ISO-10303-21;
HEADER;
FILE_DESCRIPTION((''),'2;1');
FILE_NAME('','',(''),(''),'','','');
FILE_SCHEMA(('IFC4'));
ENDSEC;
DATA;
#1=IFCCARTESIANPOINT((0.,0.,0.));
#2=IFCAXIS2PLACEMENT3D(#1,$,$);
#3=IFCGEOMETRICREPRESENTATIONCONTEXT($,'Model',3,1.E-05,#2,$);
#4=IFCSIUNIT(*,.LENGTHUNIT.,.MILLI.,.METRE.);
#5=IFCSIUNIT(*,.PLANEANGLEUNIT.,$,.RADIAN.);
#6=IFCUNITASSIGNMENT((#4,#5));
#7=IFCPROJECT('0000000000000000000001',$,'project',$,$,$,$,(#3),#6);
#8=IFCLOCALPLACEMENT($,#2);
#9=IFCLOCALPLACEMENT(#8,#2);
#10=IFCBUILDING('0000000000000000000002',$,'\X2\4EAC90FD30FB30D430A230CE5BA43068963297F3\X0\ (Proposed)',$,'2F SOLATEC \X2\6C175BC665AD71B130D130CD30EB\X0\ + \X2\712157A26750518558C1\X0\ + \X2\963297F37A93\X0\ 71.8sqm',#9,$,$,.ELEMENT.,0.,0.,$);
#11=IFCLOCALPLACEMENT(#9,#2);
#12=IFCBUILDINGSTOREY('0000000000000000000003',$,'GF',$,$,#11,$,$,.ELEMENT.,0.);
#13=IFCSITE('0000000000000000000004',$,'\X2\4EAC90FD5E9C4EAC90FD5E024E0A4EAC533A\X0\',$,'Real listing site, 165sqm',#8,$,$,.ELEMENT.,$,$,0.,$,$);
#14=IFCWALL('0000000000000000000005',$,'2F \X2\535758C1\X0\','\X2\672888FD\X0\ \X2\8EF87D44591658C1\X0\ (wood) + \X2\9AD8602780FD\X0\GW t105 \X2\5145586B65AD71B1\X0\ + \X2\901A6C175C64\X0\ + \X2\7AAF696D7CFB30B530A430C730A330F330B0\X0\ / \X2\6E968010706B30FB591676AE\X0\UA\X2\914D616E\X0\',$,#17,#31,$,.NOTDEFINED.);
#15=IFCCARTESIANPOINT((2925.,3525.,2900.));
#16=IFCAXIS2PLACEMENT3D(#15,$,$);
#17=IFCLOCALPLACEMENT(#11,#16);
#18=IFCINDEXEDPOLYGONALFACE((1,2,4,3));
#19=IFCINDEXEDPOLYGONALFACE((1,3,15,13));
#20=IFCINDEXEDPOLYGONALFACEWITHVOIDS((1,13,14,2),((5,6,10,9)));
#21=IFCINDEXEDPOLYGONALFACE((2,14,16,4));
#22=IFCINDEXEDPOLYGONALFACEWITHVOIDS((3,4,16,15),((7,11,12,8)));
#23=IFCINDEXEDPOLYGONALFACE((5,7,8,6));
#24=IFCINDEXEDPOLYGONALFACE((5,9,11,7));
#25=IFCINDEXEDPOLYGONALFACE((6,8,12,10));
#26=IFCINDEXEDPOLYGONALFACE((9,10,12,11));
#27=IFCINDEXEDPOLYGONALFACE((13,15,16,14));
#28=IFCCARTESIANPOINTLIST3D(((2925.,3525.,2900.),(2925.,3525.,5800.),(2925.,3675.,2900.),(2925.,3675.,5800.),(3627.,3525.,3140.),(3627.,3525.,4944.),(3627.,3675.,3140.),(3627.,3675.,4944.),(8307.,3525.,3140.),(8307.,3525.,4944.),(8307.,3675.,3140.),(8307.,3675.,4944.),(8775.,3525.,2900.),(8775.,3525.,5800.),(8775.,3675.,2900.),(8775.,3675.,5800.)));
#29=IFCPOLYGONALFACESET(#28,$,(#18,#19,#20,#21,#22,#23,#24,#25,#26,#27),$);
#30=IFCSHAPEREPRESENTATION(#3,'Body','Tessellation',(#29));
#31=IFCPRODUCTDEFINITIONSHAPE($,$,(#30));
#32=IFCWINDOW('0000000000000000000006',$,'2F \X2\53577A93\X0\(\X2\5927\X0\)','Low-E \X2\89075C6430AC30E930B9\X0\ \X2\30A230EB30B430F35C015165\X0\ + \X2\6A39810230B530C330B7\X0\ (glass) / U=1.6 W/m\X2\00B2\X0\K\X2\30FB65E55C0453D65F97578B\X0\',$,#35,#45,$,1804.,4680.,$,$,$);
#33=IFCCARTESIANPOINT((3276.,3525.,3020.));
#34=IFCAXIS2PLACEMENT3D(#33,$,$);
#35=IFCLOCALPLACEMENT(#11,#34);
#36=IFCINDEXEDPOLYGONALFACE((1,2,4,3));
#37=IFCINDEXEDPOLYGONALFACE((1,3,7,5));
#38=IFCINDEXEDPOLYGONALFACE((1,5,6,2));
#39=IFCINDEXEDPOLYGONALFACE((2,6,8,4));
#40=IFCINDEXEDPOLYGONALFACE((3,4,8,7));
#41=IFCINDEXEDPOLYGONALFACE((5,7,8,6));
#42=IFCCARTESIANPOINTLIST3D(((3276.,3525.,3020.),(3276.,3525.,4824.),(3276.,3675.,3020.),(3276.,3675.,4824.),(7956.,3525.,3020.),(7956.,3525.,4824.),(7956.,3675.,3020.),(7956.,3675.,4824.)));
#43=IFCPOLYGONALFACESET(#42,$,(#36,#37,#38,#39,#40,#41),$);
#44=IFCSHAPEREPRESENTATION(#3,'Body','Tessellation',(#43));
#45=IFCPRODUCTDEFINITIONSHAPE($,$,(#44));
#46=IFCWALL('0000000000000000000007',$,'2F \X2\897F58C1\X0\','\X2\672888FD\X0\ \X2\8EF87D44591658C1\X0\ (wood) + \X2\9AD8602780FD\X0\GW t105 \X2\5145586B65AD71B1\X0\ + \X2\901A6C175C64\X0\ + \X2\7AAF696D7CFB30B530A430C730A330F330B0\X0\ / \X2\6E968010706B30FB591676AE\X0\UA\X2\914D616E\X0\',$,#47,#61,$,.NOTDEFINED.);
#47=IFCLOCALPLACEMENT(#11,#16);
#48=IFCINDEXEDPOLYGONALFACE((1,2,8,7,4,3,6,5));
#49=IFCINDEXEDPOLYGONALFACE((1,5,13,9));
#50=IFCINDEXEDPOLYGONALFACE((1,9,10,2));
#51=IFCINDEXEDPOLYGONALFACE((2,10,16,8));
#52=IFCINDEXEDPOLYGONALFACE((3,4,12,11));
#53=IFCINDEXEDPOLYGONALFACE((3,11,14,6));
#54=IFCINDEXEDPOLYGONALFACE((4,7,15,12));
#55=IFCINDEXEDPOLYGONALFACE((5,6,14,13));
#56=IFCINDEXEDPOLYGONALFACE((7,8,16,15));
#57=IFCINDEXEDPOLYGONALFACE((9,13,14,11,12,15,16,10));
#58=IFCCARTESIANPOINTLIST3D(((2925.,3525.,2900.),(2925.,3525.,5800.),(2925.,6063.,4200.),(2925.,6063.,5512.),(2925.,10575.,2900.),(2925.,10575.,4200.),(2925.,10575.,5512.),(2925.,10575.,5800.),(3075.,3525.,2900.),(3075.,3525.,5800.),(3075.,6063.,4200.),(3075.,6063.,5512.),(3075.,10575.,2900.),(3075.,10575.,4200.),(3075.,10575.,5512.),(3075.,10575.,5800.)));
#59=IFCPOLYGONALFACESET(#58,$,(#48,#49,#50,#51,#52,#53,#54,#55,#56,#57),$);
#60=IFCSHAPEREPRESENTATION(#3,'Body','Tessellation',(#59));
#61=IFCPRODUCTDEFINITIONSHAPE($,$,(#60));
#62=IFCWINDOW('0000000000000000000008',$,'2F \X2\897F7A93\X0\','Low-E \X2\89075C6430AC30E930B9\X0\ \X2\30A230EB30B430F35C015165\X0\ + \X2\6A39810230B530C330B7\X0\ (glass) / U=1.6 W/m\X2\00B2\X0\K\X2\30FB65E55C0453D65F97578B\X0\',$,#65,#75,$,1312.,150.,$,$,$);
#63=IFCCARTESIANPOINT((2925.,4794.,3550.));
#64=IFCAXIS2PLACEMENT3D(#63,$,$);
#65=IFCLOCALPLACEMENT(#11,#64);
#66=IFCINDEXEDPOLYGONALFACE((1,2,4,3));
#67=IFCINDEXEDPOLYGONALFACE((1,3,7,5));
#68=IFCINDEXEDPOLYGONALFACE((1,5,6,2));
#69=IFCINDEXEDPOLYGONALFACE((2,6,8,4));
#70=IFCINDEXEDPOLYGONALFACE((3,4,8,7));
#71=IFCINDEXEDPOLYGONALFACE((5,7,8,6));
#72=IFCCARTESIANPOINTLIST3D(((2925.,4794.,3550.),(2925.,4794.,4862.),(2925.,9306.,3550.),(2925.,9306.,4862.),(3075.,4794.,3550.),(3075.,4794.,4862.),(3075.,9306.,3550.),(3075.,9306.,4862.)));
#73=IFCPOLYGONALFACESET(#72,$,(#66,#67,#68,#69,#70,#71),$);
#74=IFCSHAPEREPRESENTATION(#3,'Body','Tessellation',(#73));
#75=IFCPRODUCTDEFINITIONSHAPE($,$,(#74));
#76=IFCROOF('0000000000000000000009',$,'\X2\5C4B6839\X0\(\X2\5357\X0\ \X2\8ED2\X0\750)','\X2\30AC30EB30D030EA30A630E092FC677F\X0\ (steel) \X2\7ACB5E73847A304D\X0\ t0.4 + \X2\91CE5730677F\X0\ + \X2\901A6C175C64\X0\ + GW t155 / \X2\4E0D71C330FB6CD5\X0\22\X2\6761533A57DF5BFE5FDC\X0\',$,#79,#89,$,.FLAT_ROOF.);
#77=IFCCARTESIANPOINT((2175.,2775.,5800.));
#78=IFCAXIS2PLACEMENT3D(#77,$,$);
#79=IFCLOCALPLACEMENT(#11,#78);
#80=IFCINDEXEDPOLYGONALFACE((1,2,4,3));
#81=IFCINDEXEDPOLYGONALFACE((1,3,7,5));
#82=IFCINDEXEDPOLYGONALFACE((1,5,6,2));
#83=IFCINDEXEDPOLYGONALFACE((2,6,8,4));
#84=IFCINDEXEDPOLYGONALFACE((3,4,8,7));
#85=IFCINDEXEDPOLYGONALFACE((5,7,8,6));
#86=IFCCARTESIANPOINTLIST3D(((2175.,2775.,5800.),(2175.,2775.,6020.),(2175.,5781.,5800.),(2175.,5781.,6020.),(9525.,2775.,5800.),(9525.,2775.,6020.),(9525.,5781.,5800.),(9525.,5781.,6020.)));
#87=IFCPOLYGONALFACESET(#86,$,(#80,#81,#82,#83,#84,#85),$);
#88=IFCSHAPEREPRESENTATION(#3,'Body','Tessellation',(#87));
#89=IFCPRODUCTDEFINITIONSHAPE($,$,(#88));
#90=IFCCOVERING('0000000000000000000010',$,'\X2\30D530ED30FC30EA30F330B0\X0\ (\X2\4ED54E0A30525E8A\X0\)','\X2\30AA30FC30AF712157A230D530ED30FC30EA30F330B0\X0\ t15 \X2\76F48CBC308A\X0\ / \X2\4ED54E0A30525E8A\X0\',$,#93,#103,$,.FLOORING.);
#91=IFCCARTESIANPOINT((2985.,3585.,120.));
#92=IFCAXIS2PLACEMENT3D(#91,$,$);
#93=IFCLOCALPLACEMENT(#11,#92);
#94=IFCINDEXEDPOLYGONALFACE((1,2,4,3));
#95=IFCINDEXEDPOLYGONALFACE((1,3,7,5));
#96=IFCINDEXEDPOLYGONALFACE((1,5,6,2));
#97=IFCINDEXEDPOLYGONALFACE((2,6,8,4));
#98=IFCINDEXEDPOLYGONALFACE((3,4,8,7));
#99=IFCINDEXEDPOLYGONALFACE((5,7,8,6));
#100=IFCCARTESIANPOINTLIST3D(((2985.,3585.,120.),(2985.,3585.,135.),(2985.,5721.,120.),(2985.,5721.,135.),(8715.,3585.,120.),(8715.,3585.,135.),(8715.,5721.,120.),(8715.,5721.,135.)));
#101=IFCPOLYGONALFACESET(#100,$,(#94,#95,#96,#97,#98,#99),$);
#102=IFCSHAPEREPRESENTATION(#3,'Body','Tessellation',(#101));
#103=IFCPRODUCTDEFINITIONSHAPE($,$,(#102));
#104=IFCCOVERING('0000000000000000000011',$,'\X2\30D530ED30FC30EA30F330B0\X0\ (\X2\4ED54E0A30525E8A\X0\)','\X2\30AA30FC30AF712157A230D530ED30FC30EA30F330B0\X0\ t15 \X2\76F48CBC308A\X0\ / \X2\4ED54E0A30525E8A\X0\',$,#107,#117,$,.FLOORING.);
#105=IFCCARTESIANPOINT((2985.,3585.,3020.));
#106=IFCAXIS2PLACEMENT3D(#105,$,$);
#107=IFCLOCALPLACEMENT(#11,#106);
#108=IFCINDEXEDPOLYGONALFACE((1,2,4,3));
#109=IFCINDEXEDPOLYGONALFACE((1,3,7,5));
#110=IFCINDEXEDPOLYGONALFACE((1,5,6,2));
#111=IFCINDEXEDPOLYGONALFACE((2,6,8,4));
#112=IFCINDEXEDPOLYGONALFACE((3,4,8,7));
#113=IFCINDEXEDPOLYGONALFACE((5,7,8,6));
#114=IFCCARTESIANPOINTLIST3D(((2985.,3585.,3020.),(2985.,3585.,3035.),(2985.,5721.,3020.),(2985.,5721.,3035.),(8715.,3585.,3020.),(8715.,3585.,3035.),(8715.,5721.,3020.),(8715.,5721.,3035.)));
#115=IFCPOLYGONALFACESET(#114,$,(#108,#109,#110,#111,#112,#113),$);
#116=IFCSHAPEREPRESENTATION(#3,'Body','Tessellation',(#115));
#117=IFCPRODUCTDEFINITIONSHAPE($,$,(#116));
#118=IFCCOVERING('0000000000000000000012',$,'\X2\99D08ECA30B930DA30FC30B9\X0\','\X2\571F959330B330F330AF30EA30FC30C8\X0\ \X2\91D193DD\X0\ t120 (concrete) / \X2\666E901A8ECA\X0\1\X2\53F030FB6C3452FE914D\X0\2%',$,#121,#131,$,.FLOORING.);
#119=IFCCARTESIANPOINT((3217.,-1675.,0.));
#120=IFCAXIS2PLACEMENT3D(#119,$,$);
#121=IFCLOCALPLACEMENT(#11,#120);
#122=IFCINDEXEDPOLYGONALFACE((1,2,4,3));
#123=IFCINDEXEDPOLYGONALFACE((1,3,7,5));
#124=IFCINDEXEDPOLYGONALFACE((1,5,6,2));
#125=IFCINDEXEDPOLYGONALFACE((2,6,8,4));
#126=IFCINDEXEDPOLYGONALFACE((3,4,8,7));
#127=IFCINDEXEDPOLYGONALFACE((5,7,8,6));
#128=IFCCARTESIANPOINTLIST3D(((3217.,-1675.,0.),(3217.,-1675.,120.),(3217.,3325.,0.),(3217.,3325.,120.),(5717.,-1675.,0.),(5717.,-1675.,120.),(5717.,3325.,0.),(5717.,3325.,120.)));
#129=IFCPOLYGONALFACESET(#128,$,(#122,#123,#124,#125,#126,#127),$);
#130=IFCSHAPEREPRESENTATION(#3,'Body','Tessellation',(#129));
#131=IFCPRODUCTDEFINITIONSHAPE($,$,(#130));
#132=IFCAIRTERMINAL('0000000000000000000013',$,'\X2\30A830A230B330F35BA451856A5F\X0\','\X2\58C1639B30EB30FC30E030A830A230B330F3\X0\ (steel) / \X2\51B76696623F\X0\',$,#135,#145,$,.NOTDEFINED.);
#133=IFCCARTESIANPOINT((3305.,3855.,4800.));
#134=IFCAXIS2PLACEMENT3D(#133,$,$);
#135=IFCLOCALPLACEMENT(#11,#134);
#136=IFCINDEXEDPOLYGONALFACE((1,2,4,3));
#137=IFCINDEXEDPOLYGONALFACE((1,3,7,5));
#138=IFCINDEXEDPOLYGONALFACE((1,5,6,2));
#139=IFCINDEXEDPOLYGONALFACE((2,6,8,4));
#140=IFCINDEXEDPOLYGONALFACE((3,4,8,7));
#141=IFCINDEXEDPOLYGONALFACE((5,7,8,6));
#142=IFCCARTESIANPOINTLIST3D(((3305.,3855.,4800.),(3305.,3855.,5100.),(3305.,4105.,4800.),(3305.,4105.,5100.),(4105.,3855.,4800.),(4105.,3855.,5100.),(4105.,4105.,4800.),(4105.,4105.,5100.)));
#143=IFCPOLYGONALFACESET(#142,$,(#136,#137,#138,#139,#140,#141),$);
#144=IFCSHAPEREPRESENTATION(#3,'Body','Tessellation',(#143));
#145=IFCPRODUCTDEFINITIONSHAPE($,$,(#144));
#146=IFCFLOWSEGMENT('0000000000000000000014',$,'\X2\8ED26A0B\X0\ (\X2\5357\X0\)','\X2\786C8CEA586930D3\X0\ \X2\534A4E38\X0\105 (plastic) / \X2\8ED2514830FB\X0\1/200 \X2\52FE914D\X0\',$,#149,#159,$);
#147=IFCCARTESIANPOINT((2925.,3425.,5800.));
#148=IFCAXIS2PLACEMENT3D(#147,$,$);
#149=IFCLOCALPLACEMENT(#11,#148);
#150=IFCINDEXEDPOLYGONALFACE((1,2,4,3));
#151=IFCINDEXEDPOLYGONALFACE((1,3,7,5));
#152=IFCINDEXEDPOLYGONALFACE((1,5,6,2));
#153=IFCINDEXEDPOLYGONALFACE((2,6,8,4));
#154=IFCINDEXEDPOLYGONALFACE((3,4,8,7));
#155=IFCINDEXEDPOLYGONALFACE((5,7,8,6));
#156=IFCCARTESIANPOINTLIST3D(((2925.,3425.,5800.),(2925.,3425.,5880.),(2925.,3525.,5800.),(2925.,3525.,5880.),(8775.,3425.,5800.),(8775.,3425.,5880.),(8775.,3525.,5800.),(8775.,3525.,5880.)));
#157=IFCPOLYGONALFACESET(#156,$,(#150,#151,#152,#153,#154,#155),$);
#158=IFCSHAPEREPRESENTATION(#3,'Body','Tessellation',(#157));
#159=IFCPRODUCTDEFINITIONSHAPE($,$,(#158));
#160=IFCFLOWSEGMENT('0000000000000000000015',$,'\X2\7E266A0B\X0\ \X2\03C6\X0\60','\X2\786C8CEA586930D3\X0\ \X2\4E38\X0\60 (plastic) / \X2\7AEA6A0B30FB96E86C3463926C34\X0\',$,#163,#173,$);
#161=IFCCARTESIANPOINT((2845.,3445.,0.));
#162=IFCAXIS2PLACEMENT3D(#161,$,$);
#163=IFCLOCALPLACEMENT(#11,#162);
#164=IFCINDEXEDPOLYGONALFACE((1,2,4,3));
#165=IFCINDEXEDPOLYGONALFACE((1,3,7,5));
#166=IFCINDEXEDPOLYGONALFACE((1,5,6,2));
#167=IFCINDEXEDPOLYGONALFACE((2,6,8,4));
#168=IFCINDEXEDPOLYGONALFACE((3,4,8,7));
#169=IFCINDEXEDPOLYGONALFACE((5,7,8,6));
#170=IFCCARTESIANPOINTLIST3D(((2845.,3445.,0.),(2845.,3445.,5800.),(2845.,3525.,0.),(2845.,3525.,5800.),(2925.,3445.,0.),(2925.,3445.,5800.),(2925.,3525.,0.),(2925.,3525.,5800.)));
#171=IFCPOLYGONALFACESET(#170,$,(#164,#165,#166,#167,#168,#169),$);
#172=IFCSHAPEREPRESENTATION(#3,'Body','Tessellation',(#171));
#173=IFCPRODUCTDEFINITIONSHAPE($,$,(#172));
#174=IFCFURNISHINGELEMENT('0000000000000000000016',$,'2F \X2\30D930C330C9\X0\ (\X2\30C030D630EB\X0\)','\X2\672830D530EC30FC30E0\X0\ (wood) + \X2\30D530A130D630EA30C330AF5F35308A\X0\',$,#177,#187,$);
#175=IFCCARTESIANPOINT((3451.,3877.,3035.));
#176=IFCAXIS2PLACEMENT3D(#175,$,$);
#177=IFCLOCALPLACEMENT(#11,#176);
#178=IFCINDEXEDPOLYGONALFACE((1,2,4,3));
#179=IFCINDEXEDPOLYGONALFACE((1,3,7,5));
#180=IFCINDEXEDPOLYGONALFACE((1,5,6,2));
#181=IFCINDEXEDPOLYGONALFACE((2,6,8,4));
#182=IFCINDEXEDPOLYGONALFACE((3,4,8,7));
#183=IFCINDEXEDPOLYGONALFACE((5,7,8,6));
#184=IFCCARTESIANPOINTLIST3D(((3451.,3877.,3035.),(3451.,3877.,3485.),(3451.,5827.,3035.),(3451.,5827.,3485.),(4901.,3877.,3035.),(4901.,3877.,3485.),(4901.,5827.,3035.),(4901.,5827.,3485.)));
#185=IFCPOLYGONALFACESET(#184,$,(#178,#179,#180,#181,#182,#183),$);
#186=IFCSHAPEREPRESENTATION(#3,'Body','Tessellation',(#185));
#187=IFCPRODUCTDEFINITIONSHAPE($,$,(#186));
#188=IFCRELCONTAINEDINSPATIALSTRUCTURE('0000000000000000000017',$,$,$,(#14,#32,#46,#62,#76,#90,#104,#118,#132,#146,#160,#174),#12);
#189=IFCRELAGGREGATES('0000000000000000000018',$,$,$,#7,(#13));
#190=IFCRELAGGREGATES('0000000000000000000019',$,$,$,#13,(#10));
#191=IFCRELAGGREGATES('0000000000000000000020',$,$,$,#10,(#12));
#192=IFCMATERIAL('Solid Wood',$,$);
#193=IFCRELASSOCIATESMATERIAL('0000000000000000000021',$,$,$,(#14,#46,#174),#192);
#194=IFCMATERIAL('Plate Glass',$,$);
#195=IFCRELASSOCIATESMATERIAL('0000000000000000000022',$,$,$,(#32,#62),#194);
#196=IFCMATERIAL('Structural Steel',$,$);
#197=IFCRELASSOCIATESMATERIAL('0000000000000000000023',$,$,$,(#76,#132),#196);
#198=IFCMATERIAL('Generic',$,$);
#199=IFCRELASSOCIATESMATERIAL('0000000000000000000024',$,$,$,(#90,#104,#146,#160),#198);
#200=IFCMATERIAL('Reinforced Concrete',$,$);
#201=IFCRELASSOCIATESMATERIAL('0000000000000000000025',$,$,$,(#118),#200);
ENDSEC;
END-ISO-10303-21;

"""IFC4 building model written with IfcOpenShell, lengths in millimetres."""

from ifc_helpers import new_model, si_unit, frame, frame_2d, origin, place, context, project, spatial, rectangle, extrude, material, element, fill, save


model = new_model("IFC4")

# Units and contexts
model_context = context("Model", 3, precision=1e-05, world=origin())
ifc_project = project(units=[si_unit("LENGTHUNIT", "METRE", prefix="MILLI"), si_unit("PLANEANGLEUNIT", "RADIAN")], contexts=[model_context])

# Site, building, storey
site_placement = place(None, origin())
site = spatial("IfcSite", under=ifc_project, at=site_placement, Name="京都府京都市上京区", ObjectType="Real listing site, 165sqm", CompositionType="ELEMENT", RefElevation=0.0)
building_placement = place(site_placement, origin())
building = spatial("IfcBuilding", under=site, at=building_placement, Name="京都・ピアノ室と防音 (Proposed)", ObjectType="2F SOLATEC 気密断熱パネル + 無垢材内壁 + 防音窓 71.8sqm", CompositionType="ELEMENT", ElevationOfRefHeight=0.0, ElevationOfTerrain=0.0)
storey_placement = place(building_placement, origin())
storey = spatial("IfcBuildingStorey", under=building, at=storey_placement, Name="GF", CompositionType="ELEMENT", Elevation=0.0)

# Shared definitions
ifc_material_1 = material(Name="Solid Wood")

# Shared definitions
ifc_material_2 = material(Name="Reinforced Concrete")

# Shared definitions
ifc_material_3 = material(Name="Plate Glass")

# Walls, openings, windows
wall_1_placement = place(storey_placement, frame((2925.0, 3525.0, 2900.0)))
wall_1 = element("IfcWall", 1, at=wall_1_placement, inside=storey, material=ifc_material_1, Name="2F 南壁", Description="木製 軸組外壁 (wood) + 高性能GW t105 充填断熱 + 通気層 + 窯業系サイディング / 準耐火・外皮UA配慮", PredefinedType="NOTDEFINED", context=model_context, shape_type="SweptSolid", body=[
    extrude(rectangle(XDim=5850.0, YDim=150.0, at=frame_2d((2925.0, 75.0))), frame((2925.0, 3525.0, 2900.0)), (0.0, 0.0, 1.0), 2900.0),
])
opening_1_placement = place(storey_placement, frame((3276.0, 3525.0, 3020.0)))
opening_1 = element("IfcOpeningElement", 2, at=opening_1_placement, cuts=wall_1, PredefinedType="NOTDEFINED", context=model_context, shape_type="SweptSolid", body=[
    extrude(rectangle(XDim=4680.0, YDim=150.0, at=frame_2d((2340.0, 75.0))), frame((3276.0, 3525.0, 3020.0)), (0.0, 0.0, 1.0), 1804.0),
])
window_1_placement = place(storey_placement, frame((3276.0, 3525.0, 3020.0)))
window_1 = element("IfcWindow", 3, at=window_1_placement, inside=storey, material=ifc_material_3, Name="2F 南窓(大)", Description="Low-E 複層ガラス アルゴン封入 + 樹脂サッシ (glass) / U=1.6 W/m²K・日射取得型", OverallHeight=1804.0, OverallWidth=4680.0, context=model_context, shape_type="SweptSolid", body=[
    extrude(rectangle(XDim=4680.0, YDim=150.0, at=frame_2d((2340.0, 75.0))), frame((3276.0, 3525.0, 3020.0)), (0.0, 0.0, 1.0), 1804.0),
])
fill(opening_1, window_1)
wall_2_placement = place(storey_placement, frame((2925.0, 3525.0, 2900.0)))
wall_2 = element("IfcWall", 4, at=wall_2_placement, inside=storey, material=ifc_material_1, Name="2F 西壁", Description="木製 軸組外壁 (wood) + 高性能GW t105 充填断熱 + 通気層 + 窯業系サイディング / 準耐火・外皮UA配慮", PredefinedType="NOTDEFINED", context=model_context, shape_type="SweptSolid", body=[
    extrude(rectangle(XDim=150.0, YDim=7050.0, at=frame_2d((75.0, 3525.0))), frame((2925.0, 3525.0, 2900.0)), (0.0, 0.0, 1.0), 2900.0),
])
opening_2_placement = place(storey_placement, frame((2925.0, 4794.0, 3550.0)))
opening_2 = element("IfcOpeningElement", 5, at=opening_2_placement, cuts=wall_2, PredefinedType="NOTDEFINED", context=model_context, shape_type="SweptSolid", body=[
    extrude(rectangle(XDim=150.0, YDim=4512.0, at=frame_2d((75.0, 2256.0))), frame((2925.0, 4794.0, 3550.0)), (0.0, 0.0, 1.0), 1312.0),
])
window_2_placement = place(storey_placement, frame((2925.0, 4794.0, 3550.0)))
window_2 = element("IfcWindow", 6, at=window_2_placement, inside=storey, material=ifc_material_3, Name="2F 西窓", Description="Low-E 複層ガラス アルゴン封入 + 樹脂サッシ (glass) / U=1.6 W/m²K・日射取得型", OverallHeight=1312.0, OverallWidth=150.0, context=model_context, shape_type="SweptSolid", body=[
    extrude(rectangle(XDim=150.0, YDim=4512.0, at=frame_2d((75.0, 2256.0))), frame((2925.0, 4794.0, 3550.0)), (0.0, 0.0, 1.0), 1312.0),
])
fill(opening_2, window_2)

# Roof
ifc_material_4 = material(Name="Structural Steel")
for number, where, name in (
    (7, (2175.0, 2775.0, 5800.0), "屋根(南 軒750)"),
):
    element("IfcRoof", number, at=place(storey_placement, frame(where)), inside=storey, material=ifc_material_4, Name=name, Description="ガルバリウム鋼板 (steel) 立平葺き t0.4 + 野地板 + 通気層 + GW t155 / 不燃・法22条区域対応", PredefinedType="FLAT_ROOF", context=model_context, shape_type="SweptSolid", body=[
        extrude(rectangle(XDim=7350.0, YDim=3006.0, at=frame_2d((3675.0, 1503.0))), frame((2175.0, 2775.0, 5800.0)), (0.0, 0.0, 1.0), 220.0),
    ])

# Coverings
ifc_material_5 = material(Name="Generic")
covering_1_placement = place(storey_placement, frame((2985.0, 3585.0, 120.0)))
element("IfcCovering", 8, at=covering_1_placement, inside=storey, material=ifc_material_5, Name="フローリング (仕上げ床)", Description="オーク無垢フローリング t15 直貼り / 仕上げ床", PredefinedType="FLOORING", context=model_context, shape_type="SweptSolid", body=[
    extrude(rectangle(XDim=5730.0, YDim=2136.0, at=frame_2d((2865.0, 1068.0))), frame((2985.0, 3585.0, 120.0)), (0.0, 0.0, 1.0), 15.0),
])
covering_2_placement = place(storey_placement, frame((2985.0, 3585.0, 3020.0)))
element("IfcCovering", 9, at=covering_2_placement, inside=storey, material=ifc_material_5, Name="フローリング (仕上げ床)", Description="オーク無垢フローリング t15 直貼り / 仕上げ床", PredefinedType="FLOORING", context=model_context, shape_type="SweptSolid", body=[
    extrude(rectangle(XDim=5730.0, YDim=2136.0, at=frame_2d((2865.0, 1068.0))), frame((2985.0, 3585.0, 3020.0)), (0.0, 0.0, 1.0), 15.0),
])
covering_3_placement = place(storey_placement, frame((3217.0, -1675.0, 0.0)))
element("IfcCovering", 10, at=covering_3_placement, inside=storey, material=ifc_material_2, Name="駐車スペース", Description="土間コンクリート 金鏝 t120 (concrete) / 普通車1台・水勾配2%", PredefinedType="FLOORING", context=model_context, shape_type="SweptSolid", body=[
    extrude(rectangle(XDim=2500.0, YDim=5000.0, at=frame_2d((1250.0, 2500.0))), frame((3217.0, -1675.0, 0.0)), (0.0, 0.0, 1.0), 120.0),
])

# Air terminal
air_terminal_placement = place(storey_placement, frame((3305.0, 3855.0, 4800.0)))
element("IfcAirTerminal", 11, at=air_terminal_placement, inside=storey, material=ifc_material_4, Name="エアコン室内機", Description="壁掛ルームエアコン (steel) / 冷暖房", PredefinedType="NOTDEFINED", context=model_context, shape_type="SweptSolid", body=[
    extrude(rectangle(XDim=800.0, YDim=250.0, at=frame_2d((400.0, 125.0))), frame((3305.0, 3855.0, 4800.0)), (0.0, 0.0, 1.0), 300.0),
])

# Flow segments
flow_segment_1_placement = place(storey_placement, frame((2925.0, 3425.0, 5800.0)))
element("IfcFlowSegment", 12, at=flow_segment_1_placement, inside=storey, material=ifc_material_5, Name="軒樋 (南)", Description="硬質塩ビ 半丸105 (plastic) / 軒先・1/200 勾配", context=model_context, shape_type="SweptSolid", body=[
    extrude(rectangle(XDim=5850.0, YDim=100.0, at=frame_2d((2925.0, 50.0))), frame((2925.0, 3425.0, 5800.0)), (0.0, 0.0, 1.0), 80.0),
])
flow_segment_2_placement = place(storey_placement, frame((2845.0, 3445.0, 0.0)))
element("IfcFlowSegment", 13, at=flow_segment_2_placement, inside=storey, material=ifc_material_5, Name="縦樋 φ60", Description="硬質塩ビ 丸60 (plastic) / 竪樋・雨水排水", context=model_context, shape_type="SweptSolid", body=[
    extrude(rectangle(XDim=80.0, YDim=80.0, at=frame_2d((40.0, 40.0))), frame((2845.0, 3445.0, 0.0)), (0.0, 0.0, 1.0), 5800.0),
])

# Furnishing element
furnishing_placement = place(storey_placement, frame((3451.0, 3877.0, 3035.0)))
element("IfcFurnishingElement", 14, at=furnishing_placement, inside=storey, material=ifc_material_1, Name="2F ベッド (ダブル)", Description="木フレーム (wood) + ファブリック張り", context=model_context, shape_type="SweptSolid", body=[
    extrude(rectangle(XDim=1450.0, YDim=1950.0, at=frame_2d((725.0, 975.0))), frame((3451.0, 3877.0, 3035.0)), (0.0, 0.0, 1.0), 450.0),
])

save(model, "model.ifc")
